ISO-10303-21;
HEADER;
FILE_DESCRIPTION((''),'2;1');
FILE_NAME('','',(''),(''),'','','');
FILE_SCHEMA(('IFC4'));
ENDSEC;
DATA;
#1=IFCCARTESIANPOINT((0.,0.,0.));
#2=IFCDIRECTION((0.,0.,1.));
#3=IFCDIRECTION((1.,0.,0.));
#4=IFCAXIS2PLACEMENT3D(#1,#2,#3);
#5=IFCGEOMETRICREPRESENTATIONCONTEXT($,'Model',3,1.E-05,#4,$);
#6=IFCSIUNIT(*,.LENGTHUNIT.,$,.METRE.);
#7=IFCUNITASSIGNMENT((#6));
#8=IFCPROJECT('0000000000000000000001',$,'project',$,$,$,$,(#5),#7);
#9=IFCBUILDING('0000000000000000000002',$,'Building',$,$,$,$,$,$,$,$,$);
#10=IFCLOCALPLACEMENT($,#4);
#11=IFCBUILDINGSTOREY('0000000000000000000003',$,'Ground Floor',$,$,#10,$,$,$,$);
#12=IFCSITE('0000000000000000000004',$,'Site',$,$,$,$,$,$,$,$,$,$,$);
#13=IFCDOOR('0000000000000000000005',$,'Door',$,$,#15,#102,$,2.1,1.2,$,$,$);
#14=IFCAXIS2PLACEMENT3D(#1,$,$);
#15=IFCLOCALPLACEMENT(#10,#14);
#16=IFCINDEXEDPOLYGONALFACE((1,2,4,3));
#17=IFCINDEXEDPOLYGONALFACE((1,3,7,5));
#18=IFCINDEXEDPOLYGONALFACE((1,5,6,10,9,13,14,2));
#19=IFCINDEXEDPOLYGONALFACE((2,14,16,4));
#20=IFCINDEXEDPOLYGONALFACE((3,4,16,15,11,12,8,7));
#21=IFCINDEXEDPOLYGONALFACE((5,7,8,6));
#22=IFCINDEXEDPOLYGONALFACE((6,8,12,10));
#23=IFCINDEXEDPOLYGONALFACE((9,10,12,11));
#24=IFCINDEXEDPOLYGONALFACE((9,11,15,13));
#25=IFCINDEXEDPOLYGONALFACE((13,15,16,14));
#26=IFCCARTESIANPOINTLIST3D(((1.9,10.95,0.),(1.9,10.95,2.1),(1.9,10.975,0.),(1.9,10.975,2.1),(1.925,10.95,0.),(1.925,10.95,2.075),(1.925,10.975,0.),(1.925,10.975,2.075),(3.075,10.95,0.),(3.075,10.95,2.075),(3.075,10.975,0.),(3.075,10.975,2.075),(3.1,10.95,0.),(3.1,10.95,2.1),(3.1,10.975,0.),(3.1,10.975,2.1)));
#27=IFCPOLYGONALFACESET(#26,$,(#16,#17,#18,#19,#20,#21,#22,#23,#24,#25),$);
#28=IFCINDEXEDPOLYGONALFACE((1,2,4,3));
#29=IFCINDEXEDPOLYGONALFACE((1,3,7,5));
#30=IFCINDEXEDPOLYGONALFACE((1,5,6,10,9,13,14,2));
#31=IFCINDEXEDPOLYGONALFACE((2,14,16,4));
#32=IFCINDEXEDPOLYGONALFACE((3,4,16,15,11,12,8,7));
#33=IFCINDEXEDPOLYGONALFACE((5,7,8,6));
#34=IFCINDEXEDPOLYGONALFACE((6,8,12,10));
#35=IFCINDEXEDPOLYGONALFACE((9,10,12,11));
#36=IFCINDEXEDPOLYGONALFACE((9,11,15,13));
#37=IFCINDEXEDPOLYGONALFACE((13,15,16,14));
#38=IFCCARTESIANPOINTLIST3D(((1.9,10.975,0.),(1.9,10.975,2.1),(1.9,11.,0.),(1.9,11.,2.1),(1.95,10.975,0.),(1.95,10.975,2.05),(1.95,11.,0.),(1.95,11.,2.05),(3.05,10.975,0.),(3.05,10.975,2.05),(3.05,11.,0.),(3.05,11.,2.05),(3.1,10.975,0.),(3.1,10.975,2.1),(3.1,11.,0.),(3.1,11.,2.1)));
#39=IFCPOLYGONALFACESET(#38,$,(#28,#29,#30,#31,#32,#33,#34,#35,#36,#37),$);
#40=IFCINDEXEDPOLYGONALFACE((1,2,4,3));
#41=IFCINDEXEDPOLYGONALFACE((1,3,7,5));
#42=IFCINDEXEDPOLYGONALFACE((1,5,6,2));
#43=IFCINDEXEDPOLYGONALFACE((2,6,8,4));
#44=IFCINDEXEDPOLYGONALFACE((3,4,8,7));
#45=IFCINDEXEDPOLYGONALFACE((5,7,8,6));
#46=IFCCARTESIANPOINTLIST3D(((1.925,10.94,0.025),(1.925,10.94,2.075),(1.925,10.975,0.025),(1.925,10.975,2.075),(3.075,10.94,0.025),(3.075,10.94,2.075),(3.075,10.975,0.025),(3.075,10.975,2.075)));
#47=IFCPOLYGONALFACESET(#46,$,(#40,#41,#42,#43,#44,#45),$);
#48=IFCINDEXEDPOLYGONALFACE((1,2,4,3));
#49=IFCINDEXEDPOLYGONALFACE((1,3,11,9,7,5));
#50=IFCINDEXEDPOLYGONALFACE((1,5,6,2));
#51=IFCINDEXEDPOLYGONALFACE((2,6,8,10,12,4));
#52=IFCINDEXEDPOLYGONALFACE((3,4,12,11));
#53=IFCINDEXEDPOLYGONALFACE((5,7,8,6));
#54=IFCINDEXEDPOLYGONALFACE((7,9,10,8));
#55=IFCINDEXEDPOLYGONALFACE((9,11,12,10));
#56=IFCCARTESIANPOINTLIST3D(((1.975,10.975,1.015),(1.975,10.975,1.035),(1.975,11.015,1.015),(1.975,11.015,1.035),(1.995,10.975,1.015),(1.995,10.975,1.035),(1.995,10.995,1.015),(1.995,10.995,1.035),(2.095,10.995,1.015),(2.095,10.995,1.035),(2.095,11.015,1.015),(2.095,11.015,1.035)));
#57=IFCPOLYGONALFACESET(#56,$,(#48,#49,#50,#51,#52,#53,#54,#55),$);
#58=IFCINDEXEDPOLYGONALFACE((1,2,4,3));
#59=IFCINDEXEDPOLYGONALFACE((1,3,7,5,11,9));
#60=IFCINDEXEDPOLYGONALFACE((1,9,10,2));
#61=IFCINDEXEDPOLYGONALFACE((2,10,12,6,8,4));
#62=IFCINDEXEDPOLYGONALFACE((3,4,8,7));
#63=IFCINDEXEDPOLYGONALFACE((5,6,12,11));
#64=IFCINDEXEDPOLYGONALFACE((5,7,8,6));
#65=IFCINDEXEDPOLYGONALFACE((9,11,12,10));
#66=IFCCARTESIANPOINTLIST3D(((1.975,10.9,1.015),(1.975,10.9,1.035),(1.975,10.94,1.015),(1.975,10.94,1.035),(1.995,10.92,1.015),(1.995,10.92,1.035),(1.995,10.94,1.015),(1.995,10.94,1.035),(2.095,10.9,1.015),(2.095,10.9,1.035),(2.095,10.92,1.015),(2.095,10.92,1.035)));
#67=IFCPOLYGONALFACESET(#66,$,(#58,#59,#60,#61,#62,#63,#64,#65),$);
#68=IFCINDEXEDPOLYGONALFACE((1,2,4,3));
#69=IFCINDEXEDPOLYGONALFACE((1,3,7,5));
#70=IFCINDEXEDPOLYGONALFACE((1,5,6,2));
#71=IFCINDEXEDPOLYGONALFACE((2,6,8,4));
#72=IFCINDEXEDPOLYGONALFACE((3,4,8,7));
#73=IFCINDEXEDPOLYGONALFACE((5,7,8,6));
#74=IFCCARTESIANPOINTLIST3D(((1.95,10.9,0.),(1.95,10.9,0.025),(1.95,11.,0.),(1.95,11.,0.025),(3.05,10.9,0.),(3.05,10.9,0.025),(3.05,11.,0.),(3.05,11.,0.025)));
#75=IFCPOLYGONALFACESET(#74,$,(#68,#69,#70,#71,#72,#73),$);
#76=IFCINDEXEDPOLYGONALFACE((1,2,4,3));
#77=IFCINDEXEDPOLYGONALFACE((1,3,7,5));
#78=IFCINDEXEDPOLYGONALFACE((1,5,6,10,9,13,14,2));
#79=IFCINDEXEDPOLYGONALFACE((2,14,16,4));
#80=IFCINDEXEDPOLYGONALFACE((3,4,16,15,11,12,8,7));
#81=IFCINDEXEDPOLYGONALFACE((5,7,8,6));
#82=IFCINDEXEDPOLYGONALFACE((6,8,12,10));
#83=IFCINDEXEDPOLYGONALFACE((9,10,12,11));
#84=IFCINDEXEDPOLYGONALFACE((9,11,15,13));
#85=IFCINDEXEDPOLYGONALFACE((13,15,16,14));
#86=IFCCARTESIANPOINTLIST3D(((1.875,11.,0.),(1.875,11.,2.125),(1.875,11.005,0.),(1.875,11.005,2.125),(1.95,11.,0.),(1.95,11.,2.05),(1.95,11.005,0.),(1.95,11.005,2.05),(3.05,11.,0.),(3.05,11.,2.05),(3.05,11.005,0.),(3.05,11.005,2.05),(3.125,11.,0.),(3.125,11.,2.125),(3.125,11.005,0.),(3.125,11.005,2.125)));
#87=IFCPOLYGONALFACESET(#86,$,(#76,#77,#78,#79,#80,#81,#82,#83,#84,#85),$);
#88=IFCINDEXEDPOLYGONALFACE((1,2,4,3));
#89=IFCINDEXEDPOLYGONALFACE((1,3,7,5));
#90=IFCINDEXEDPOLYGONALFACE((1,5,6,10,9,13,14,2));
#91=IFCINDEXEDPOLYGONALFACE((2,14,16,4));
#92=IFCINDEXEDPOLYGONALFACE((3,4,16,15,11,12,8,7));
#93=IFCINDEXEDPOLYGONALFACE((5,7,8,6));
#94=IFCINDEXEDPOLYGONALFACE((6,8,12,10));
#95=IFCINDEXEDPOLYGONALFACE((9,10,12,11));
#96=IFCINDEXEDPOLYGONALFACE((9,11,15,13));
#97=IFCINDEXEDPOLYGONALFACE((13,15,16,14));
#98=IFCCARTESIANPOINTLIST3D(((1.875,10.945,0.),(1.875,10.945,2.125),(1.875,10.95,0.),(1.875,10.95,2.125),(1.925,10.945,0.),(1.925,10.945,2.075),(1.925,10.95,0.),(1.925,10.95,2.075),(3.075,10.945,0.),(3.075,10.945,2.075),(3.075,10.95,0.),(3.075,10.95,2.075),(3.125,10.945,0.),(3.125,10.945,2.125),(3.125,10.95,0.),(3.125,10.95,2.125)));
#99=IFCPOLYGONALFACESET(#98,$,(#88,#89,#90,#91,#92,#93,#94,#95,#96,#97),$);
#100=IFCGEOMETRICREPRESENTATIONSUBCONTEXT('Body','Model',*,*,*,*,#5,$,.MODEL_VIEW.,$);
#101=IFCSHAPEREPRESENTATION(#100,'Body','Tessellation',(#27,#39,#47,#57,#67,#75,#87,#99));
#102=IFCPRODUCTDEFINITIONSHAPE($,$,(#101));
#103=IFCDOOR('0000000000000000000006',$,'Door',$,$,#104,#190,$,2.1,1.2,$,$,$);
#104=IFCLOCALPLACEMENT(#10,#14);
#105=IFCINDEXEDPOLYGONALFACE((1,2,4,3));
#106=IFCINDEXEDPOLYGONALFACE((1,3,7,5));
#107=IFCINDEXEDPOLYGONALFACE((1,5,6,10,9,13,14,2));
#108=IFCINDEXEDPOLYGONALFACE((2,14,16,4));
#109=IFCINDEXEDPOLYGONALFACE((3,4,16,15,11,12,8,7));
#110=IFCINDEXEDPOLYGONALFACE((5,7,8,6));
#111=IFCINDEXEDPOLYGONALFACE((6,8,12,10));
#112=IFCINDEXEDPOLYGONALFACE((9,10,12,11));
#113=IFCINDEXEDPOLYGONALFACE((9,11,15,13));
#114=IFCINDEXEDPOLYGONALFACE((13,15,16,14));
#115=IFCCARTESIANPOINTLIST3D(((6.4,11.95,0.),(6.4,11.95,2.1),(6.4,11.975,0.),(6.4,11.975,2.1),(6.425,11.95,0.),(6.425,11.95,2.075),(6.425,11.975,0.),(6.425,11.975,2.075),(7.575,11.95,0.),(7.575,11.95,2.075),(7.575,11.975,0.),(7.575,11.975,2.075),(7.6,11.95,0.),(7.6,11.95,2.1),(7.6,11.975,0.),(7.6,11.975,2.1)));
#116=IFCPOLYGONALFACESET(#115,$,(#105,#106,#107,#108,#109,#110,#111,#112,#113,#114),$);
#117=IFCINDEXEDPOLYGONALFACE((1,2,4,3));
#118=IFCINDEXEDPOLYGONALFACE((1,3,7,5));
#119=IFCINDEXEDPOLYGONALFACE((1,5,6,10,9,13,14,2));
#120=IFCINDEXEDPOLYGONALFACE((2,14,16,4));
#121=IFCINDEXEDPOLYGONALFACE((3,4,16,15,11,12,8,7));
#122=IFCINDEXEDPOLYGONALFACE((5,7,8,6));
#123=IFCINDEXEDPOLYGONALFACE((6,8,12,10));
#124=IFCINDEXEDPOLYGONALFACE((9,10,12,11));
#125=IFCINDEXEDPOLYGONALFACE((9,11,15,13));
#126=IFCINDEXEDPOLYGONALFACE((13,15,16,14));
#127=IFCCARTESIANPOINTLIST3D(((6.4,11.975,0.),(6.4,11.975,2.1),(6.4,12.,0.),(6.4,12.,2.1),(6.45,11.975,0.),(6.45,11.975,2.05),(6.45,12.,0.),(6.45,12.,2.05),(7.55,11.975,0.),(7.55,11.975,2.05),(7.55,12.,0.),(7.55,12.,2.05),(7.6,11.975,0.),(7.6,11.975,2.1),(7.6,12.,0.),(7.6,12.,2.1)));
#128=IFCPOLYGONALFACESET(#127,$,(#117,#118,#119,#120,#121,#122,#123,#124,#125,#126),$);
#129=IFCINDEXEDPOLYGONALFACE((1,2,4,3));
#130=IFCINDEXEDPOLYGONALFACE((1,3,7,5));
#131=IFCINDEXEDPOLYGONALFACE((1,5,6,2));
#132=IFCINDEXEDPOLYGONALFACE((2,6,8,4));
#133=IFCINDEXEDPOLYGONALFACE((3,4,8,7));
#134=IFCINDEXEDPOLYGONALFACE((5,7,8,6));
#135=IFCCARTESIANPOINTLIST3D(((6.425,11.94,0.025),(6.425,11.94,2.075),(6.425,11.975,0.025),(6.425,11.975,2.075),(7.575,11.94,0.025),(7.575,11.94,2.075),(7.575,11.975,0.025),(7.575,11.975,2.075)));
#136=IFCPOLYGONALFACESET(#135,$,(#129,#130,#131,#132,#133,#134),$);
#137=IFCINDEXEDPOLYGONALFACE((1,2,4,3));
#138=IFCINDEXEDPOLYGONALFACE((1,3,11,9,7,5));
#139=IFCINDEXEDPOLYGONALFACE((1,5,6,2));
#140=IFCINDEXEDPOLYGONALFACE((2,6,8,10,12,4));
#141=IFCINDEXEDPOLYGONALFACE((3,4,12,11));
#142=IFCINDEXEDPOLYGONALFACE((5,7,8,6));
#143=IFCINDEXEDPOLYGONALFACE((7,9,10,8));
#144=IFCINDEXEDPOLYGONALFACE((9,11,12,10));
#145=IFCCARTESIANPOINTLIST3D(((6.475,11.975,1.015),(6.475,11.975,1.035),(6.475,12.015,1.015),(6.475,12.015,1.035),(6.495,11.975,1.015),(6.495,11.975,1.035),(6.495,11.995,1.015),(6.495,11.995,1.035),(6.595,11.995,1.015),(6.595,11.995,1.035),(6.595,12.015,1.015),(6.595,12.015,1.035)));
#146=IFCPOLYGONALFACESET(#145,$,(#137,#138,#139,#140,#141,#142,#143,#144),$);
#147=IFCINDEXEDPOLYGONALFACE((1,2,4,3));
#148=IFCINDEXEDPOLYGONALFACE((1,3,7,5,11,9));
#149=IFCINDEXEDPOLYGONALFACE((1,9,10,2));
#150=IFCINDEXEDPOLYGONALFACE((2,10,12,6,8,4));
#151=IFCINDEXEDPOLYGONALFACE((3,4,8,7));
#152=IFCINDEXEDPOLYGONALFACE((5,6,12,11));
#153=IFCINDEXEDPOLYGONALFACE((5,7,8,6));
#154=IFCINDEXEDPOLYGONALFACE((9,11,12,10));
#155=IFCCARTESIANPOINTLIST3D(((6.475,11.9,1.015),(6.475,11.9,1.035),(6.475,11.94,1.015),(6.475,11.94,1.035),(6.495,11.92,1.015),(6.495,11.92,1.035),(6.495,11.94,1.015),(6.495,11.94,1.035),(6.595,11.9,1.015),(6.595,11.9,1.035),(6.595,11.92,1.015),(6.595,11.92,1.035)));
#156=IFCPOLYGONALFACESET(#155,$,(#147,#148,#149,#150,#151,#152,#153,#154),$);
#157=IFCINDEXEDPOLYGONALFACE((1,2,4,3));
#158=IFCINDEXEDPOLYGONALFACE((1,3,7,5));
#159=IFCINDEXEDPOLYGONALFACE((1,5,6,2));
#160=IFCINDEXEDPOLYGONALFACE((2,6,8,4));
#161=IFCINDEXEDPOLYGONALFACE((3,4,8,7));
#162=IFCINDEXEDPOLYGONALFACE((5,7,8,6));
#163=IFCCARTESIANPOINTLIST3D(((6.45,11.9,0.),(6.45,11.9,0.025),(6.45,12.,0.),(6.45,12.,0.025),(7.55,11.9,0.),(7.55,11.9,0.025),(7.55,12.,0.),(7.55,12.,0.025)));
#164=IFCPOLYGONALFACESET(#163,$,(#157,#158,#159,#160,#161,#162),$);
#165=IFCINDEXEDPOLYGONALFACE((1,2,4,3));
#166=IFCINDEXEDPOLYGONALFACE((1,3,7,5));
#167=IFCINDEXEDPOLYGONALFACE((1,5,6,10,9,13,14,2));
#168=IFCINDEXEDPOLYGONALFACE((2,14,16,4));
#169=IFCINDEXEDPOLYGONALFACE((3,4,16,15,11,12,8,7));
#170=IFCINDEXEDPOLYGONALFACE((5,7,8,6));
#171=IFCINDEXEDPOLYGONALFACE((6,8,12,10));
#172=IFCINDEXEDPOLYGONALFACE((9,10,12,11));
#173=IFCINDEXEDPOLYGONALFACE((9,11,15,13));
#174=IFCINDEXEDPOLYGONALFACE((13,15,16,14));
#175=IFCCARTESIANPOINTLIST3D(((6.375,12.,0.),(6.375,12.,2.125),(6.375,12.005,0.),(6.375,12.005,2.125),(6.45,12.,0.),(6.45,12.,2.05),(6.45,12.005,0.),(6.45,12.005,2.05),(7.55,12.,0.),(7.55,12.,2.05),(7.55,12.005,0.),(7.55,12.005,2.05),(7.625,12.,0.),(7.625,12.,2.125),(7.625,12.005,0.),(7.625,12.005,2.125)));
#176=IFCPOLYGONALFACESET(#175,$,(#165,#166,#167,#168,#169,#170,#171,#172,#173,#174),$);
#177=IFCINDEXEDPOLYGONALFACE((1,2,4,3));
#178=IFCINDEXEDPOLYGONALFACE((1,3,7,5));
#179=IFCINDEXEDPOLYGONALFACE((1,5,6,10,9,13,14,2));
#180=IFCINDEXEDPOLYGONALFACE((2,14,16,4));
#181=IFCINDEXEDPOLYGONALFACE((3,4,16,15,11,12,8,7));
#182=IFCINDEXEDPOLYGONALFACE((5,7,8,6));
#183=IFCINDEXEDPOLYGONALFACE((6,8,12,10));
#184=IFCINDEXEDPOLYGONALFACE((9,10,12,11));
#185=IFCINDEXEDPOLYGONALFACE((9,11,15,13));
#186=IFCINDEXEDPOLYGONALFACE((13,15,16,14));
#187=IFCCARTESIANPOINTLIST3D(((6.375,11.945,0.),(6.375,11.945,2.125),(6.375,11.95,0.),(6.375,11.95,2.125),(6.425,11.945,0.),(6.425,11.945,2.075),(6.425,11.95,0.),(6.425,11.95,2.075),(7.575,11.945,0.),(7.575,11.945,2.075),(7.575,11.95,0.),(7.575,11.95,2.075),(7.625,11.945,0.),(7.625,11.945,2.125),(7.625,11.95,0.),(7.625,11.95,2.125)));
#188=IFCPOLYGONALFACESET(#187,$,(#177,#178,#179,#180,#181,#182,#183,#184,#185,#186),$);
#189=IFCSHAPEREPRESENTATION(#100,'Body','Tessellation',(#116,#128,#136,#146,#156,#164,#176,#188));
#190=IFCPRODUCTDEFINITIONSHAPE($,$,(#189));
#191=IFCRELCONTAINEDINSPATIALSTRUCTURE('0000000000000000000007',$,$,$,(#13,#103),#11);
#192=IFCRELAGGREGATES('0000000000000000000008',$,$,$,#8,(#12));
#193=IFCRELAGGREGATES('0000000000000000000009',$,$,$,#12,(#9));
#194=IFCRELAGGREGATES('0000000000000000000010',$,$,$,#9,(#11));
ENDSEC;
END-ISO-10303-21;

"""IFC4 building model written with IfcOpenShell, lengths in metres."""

from ifc_helpers import new_model, si_unit, frame, origin_with_axes, place, context, subcontext, project, spatial, line, indexed_curve, outline, extrude, element, save


model = new_model("IFC4")

# Units and contexts
model_context = context("Model", 3, precision=1e-05, world=origin_with_axes())
body_context = subcontext(model_context, "Body", "Model", "MODEL_VIEW")
ifc_project = project(units=[si_unit("LENGTHUNIT", "METRE")], contexts=[model_context])

# Site, building, storey
site = spatial("IfcSite", under=ifc_project, Name="Site")
building = spatial("IfcBuilding", under=site, Name="Building")
storey_placement = place(None, origin_with_axes())
storey = spatial("IfcBuildingStorey", under=building, at=storey_placement, Name="Ground Floor")

# Doors
door_1_placement = place(storey_placement, frame((3.1, 11.0, 0.0), z_axis=(0.0, 0.0, 1.0), x_axis=(-1.0, 0.0, 0.0)))
element("IfcDoor", 1, at=door_1_placement, inside=storey, Name="Door", OverallHeight=2.1, OverallWidth=1.2, context=body_context, shape_type="SweptSolid", body=[
    extrude(outline(indexed_curve([(0.0, 0.0), (0.0, 2.1), (1.2, 2.1), (1.2, 0.0), (1.175, 0.0), (1.175, 2.075), (0.025, 2.075), (0.025, 0.0)], segments=[line(1, 2, 3, 4, 5, 6, 7, 8, 1)])), frame((0.0, 0.025, 0.0), z_axis=(0.0, -1.0, 0.0), x_axis=(1.0, 0.0, 0.0)), (0.0, 0.0, -1.0), 0.025),
    extrude(outline(indexed_curve([(0.0, 0.0), (0.0, 2.1), (1.2, 2.1), (1.2, 0.0), (1.15, 0.0), (1.15, 2.05), (0.05, 2.05), (0.05, 0.0)], segments=[line(1, 2, 3, 4, 5, 6, 7, 8, 1)])), frame((0.0, 0.0, 0.0), z_axis=(0.0, -1.0, 0.0), x_axis=(1.0, 0.0, 0.0)), (0.0, 0.0, -1.0), 0.025),
    extrude(outline(indexed_curve([(0.0, 0.0), (1.15, 0.0), (1.15, 0.035), (0.0, 0.035)], segments=[line(1, 2, 3, 4, 1)])), frame((0.025, 0.025, 0.025), z_axis=(0.0, 0.0, 1.0), x_axis=(1.0, 0.0, 0.0)), (0.0, 0.0, 1.0), 2.05),
    extrude(outline(indexed_curve([(0.0, 0.0), (0.0, -0.04), (-0.12, -0.04), (-0.12, -0.02), (-0.02, -0.02), (-0.02, 0.0)], segments=[line(1, 2, 3, 4, 5, 6, 1)])), frame((1.125, 0.025, 1.015), z_axis=(0.0, 0.0, 1.0), x_axis=(1.0, 0.0, 0.0)), (0.0, 0.0, 1.0), 0.02),
    extrude(outline(indexed_curve([(0.0, 0.0), (0.0, 0.04), (-0.12, 0.04), (-0.12, 0.02), (-0.02, 0.02), (-0.02, 0.0)], segments=[line(1, 2, 3, 4, 5, 6, 1)])), frame((1.125, 0.06, 1.015), z_axis=(0.0, 0.0, 1.0), x_axis=(1.0, 0.0, 0.0)), (0.0, 0.0, 1.0), 0.02),
    extrude(outline(indexed_curve([(0.0, 0.0), (1.1, 0.0), (1.1, 0.1), (0.0, 0.1)], segments=[line(1, 2, 3, 4, 1)])), frame((0.05, 0.0, 0.0), z_axis=(0.0, 0.0, 1.0), x_axis=(1.0, 0.0, 0.0)), (0.0, 0.0, 1.0), 0.025),
    extrude(outline(indexed_curve([(0.0, 0.0), (0.0, 2.125), (1.25, 2.125), (1.25, 0.0), (1.175, 0.0), (1.175, 2.05), (0.075, 2.05), (0.075, 0.0)], segments=[line(1, 2, 3, 4, 5, 6, 7, 8, 1)])), frame((-0.025, -0.005, 0.0), z_axis=(0.0, -1.0, 0.0), x_axis=(1.0, 0.0, 0.0)), (0.0, 0.0, -1.0), 0.005),
    extrude(outline(indexed_curve([(0.0, 0.0), (0.0, 2.125), (1.25, 2.125), (1.25, 0.0), (1.2, 0.0), (1.2, 2.075), (0.05, 2.075), (0.05, 0.0)], segments=[line(1, 2, 3, 4, 5, 6, 7, 8, 1)])), frame((-0.025, 0.05, 0.0), z_axis=(0.0, -1.0, 0.0), x_axis=(1.0, 0.0, 0.0)), (0.0, 0.0, -1.0), 0.005),
])
door_2_placement = place(storey_placement, frame((7.6, 12.0, 0.0), z_axis=(0.0, 0.0, 1.0), x_axis=(-1.0, 0.0, 0.0)))
element("IfcDoor", 2, at=door_2_placement, inside=storey, Name="Door", OverallHeight=2.1, OverallWidth=1.2, context=body_context, shape_type="SweptSolid", body=[
    extrude(outline(indexed_curve([(0.0, 0.0), (0.0, 2.1), (1.2, 2.1), (1.2, 0.0), (1.175, 0.0), (1.175, 2.075), (0.025, 2.075), (0.025, 0.0)], segments=[line(1, 2, 3, 4, 5, 6, 7, 8, 1)])), frame((0.0, 0.025, 0.0), z_axis=(0.0, -1.0, 0.0), x_axis=(1.0, 0.0, 0.0)), (0.0, 0.0, -1.0), 0.025),
    extrude(outline(indexed_curve([(0.0, 0.0), (0.0, 2.1), (1.2, 2.1), (1.2, 0.0), (1.15, 0.0), (1.15, 2.05), (0.05, 2.05), (0.05, 0.0)], segments=[line(1, 2, 3, 4, 5, 6, 7, 8, 1)])), frame((0.0, 0.0, 0.0), z_axis=(0.0, -1.0, 0.0), x_axis=(1.0, 0.0, 0.0)), (0.0, 0.0, -1.0), 0.025),
    extrude(outline(indexed_curve([(0.0, 0.0), (1.15, 0.0), (1.15, 0.035), (0.0, 0.035)], segments=[line(1, 2, 3, 4, 1)])), frame((0.025, 0.025, 0.025), z_axis=(0.0, 0.0, 1.0), x_axis=(1.0, 0.0, 0.0)), (0.0, 0.0, 1.0), 2.05),
    extrude(outline(indexed_curve([(0.0, 0.0), (0.0, -0.04), (-0.12, -0.04), (-0.12, -0.02), (-0.02, -0.02), (-0.02, 0.0)], segments=[line(1, 2, 3, 4, 5, 6, 1)])), frame((1.125, 0.025, 1.015), z_axis=(0.0, 0.0, 1.0), x_axis=(1.0, 0.0, 0.0)), (0.0, 0.0, 1.0), 0.02),
    extrude(outline(indexed_curve([(0.0, 0.0), (0.0, 0.04), (-0.12, 0.04), (-0.12, 0.02), (-0.02, 0.02), (-0.02, 0.0)], segments=[line(1, 2, 3, 4, 5, 6, 1)])), frame((1.125, 0.06, 1.015), z_axis=(0.0, 0.0, 1.0), x_axis=(1.0, 0.0, 0.0)), (0.0, 0.0, 1.0), 0.02),
    extrude(outline(indexed_curve([(0.0, 0.0), (1.1, 0.0), (1.1, 0.1), (0.0, 0.1)], segments=[line(1, 2, 3, 4, 1)])), frame((0.05, 0.0, 0.0), z_axis=(0.0, 0.0, 1.0), x_axis=(1.0, 0.0, 0.0)), (0.0, 0.0, 1.0), 0.025),
    extrude(outline(indexed_curve([(0.0, 0.0), (0.0, 2.125), (1.25, 2.125), (1.25, 0.0), (1.175, 0.0), (1.175, 2.05), (0.075, 2.05), (0.075, 0.0)], segments=[line(1, 2, 3, 4, 5, 6, 7, 8, 1)])), frame((-0.025, -0.005, 0.0), z_axis=(0.0, -1.0, 0.0), x_axis=(1.0, 0.0, 0.0)), (0.0, 0.0, -1.0), 0.005),
    extrude(outline(indexed_curve([(0.0, 0.0), (0.0, 2.125), (1.25, 2.125), (1.25, 0.0), (1.2, 0.0), (1.2, 2.075), (0.05, 2.075), (0.05, 0.0)], segments=[line(1, 2, 3, 4, 5, 6, 7, 8, 1)])), frame((-0.025, 0.05, 0.0), z_axis=(0.0, -1.0, 0.0), x_axis=(1.0, 0.0, 0.0)), (0.0, 0.0, -1.0), 0.005),
])

save(model, "model.ifc")
